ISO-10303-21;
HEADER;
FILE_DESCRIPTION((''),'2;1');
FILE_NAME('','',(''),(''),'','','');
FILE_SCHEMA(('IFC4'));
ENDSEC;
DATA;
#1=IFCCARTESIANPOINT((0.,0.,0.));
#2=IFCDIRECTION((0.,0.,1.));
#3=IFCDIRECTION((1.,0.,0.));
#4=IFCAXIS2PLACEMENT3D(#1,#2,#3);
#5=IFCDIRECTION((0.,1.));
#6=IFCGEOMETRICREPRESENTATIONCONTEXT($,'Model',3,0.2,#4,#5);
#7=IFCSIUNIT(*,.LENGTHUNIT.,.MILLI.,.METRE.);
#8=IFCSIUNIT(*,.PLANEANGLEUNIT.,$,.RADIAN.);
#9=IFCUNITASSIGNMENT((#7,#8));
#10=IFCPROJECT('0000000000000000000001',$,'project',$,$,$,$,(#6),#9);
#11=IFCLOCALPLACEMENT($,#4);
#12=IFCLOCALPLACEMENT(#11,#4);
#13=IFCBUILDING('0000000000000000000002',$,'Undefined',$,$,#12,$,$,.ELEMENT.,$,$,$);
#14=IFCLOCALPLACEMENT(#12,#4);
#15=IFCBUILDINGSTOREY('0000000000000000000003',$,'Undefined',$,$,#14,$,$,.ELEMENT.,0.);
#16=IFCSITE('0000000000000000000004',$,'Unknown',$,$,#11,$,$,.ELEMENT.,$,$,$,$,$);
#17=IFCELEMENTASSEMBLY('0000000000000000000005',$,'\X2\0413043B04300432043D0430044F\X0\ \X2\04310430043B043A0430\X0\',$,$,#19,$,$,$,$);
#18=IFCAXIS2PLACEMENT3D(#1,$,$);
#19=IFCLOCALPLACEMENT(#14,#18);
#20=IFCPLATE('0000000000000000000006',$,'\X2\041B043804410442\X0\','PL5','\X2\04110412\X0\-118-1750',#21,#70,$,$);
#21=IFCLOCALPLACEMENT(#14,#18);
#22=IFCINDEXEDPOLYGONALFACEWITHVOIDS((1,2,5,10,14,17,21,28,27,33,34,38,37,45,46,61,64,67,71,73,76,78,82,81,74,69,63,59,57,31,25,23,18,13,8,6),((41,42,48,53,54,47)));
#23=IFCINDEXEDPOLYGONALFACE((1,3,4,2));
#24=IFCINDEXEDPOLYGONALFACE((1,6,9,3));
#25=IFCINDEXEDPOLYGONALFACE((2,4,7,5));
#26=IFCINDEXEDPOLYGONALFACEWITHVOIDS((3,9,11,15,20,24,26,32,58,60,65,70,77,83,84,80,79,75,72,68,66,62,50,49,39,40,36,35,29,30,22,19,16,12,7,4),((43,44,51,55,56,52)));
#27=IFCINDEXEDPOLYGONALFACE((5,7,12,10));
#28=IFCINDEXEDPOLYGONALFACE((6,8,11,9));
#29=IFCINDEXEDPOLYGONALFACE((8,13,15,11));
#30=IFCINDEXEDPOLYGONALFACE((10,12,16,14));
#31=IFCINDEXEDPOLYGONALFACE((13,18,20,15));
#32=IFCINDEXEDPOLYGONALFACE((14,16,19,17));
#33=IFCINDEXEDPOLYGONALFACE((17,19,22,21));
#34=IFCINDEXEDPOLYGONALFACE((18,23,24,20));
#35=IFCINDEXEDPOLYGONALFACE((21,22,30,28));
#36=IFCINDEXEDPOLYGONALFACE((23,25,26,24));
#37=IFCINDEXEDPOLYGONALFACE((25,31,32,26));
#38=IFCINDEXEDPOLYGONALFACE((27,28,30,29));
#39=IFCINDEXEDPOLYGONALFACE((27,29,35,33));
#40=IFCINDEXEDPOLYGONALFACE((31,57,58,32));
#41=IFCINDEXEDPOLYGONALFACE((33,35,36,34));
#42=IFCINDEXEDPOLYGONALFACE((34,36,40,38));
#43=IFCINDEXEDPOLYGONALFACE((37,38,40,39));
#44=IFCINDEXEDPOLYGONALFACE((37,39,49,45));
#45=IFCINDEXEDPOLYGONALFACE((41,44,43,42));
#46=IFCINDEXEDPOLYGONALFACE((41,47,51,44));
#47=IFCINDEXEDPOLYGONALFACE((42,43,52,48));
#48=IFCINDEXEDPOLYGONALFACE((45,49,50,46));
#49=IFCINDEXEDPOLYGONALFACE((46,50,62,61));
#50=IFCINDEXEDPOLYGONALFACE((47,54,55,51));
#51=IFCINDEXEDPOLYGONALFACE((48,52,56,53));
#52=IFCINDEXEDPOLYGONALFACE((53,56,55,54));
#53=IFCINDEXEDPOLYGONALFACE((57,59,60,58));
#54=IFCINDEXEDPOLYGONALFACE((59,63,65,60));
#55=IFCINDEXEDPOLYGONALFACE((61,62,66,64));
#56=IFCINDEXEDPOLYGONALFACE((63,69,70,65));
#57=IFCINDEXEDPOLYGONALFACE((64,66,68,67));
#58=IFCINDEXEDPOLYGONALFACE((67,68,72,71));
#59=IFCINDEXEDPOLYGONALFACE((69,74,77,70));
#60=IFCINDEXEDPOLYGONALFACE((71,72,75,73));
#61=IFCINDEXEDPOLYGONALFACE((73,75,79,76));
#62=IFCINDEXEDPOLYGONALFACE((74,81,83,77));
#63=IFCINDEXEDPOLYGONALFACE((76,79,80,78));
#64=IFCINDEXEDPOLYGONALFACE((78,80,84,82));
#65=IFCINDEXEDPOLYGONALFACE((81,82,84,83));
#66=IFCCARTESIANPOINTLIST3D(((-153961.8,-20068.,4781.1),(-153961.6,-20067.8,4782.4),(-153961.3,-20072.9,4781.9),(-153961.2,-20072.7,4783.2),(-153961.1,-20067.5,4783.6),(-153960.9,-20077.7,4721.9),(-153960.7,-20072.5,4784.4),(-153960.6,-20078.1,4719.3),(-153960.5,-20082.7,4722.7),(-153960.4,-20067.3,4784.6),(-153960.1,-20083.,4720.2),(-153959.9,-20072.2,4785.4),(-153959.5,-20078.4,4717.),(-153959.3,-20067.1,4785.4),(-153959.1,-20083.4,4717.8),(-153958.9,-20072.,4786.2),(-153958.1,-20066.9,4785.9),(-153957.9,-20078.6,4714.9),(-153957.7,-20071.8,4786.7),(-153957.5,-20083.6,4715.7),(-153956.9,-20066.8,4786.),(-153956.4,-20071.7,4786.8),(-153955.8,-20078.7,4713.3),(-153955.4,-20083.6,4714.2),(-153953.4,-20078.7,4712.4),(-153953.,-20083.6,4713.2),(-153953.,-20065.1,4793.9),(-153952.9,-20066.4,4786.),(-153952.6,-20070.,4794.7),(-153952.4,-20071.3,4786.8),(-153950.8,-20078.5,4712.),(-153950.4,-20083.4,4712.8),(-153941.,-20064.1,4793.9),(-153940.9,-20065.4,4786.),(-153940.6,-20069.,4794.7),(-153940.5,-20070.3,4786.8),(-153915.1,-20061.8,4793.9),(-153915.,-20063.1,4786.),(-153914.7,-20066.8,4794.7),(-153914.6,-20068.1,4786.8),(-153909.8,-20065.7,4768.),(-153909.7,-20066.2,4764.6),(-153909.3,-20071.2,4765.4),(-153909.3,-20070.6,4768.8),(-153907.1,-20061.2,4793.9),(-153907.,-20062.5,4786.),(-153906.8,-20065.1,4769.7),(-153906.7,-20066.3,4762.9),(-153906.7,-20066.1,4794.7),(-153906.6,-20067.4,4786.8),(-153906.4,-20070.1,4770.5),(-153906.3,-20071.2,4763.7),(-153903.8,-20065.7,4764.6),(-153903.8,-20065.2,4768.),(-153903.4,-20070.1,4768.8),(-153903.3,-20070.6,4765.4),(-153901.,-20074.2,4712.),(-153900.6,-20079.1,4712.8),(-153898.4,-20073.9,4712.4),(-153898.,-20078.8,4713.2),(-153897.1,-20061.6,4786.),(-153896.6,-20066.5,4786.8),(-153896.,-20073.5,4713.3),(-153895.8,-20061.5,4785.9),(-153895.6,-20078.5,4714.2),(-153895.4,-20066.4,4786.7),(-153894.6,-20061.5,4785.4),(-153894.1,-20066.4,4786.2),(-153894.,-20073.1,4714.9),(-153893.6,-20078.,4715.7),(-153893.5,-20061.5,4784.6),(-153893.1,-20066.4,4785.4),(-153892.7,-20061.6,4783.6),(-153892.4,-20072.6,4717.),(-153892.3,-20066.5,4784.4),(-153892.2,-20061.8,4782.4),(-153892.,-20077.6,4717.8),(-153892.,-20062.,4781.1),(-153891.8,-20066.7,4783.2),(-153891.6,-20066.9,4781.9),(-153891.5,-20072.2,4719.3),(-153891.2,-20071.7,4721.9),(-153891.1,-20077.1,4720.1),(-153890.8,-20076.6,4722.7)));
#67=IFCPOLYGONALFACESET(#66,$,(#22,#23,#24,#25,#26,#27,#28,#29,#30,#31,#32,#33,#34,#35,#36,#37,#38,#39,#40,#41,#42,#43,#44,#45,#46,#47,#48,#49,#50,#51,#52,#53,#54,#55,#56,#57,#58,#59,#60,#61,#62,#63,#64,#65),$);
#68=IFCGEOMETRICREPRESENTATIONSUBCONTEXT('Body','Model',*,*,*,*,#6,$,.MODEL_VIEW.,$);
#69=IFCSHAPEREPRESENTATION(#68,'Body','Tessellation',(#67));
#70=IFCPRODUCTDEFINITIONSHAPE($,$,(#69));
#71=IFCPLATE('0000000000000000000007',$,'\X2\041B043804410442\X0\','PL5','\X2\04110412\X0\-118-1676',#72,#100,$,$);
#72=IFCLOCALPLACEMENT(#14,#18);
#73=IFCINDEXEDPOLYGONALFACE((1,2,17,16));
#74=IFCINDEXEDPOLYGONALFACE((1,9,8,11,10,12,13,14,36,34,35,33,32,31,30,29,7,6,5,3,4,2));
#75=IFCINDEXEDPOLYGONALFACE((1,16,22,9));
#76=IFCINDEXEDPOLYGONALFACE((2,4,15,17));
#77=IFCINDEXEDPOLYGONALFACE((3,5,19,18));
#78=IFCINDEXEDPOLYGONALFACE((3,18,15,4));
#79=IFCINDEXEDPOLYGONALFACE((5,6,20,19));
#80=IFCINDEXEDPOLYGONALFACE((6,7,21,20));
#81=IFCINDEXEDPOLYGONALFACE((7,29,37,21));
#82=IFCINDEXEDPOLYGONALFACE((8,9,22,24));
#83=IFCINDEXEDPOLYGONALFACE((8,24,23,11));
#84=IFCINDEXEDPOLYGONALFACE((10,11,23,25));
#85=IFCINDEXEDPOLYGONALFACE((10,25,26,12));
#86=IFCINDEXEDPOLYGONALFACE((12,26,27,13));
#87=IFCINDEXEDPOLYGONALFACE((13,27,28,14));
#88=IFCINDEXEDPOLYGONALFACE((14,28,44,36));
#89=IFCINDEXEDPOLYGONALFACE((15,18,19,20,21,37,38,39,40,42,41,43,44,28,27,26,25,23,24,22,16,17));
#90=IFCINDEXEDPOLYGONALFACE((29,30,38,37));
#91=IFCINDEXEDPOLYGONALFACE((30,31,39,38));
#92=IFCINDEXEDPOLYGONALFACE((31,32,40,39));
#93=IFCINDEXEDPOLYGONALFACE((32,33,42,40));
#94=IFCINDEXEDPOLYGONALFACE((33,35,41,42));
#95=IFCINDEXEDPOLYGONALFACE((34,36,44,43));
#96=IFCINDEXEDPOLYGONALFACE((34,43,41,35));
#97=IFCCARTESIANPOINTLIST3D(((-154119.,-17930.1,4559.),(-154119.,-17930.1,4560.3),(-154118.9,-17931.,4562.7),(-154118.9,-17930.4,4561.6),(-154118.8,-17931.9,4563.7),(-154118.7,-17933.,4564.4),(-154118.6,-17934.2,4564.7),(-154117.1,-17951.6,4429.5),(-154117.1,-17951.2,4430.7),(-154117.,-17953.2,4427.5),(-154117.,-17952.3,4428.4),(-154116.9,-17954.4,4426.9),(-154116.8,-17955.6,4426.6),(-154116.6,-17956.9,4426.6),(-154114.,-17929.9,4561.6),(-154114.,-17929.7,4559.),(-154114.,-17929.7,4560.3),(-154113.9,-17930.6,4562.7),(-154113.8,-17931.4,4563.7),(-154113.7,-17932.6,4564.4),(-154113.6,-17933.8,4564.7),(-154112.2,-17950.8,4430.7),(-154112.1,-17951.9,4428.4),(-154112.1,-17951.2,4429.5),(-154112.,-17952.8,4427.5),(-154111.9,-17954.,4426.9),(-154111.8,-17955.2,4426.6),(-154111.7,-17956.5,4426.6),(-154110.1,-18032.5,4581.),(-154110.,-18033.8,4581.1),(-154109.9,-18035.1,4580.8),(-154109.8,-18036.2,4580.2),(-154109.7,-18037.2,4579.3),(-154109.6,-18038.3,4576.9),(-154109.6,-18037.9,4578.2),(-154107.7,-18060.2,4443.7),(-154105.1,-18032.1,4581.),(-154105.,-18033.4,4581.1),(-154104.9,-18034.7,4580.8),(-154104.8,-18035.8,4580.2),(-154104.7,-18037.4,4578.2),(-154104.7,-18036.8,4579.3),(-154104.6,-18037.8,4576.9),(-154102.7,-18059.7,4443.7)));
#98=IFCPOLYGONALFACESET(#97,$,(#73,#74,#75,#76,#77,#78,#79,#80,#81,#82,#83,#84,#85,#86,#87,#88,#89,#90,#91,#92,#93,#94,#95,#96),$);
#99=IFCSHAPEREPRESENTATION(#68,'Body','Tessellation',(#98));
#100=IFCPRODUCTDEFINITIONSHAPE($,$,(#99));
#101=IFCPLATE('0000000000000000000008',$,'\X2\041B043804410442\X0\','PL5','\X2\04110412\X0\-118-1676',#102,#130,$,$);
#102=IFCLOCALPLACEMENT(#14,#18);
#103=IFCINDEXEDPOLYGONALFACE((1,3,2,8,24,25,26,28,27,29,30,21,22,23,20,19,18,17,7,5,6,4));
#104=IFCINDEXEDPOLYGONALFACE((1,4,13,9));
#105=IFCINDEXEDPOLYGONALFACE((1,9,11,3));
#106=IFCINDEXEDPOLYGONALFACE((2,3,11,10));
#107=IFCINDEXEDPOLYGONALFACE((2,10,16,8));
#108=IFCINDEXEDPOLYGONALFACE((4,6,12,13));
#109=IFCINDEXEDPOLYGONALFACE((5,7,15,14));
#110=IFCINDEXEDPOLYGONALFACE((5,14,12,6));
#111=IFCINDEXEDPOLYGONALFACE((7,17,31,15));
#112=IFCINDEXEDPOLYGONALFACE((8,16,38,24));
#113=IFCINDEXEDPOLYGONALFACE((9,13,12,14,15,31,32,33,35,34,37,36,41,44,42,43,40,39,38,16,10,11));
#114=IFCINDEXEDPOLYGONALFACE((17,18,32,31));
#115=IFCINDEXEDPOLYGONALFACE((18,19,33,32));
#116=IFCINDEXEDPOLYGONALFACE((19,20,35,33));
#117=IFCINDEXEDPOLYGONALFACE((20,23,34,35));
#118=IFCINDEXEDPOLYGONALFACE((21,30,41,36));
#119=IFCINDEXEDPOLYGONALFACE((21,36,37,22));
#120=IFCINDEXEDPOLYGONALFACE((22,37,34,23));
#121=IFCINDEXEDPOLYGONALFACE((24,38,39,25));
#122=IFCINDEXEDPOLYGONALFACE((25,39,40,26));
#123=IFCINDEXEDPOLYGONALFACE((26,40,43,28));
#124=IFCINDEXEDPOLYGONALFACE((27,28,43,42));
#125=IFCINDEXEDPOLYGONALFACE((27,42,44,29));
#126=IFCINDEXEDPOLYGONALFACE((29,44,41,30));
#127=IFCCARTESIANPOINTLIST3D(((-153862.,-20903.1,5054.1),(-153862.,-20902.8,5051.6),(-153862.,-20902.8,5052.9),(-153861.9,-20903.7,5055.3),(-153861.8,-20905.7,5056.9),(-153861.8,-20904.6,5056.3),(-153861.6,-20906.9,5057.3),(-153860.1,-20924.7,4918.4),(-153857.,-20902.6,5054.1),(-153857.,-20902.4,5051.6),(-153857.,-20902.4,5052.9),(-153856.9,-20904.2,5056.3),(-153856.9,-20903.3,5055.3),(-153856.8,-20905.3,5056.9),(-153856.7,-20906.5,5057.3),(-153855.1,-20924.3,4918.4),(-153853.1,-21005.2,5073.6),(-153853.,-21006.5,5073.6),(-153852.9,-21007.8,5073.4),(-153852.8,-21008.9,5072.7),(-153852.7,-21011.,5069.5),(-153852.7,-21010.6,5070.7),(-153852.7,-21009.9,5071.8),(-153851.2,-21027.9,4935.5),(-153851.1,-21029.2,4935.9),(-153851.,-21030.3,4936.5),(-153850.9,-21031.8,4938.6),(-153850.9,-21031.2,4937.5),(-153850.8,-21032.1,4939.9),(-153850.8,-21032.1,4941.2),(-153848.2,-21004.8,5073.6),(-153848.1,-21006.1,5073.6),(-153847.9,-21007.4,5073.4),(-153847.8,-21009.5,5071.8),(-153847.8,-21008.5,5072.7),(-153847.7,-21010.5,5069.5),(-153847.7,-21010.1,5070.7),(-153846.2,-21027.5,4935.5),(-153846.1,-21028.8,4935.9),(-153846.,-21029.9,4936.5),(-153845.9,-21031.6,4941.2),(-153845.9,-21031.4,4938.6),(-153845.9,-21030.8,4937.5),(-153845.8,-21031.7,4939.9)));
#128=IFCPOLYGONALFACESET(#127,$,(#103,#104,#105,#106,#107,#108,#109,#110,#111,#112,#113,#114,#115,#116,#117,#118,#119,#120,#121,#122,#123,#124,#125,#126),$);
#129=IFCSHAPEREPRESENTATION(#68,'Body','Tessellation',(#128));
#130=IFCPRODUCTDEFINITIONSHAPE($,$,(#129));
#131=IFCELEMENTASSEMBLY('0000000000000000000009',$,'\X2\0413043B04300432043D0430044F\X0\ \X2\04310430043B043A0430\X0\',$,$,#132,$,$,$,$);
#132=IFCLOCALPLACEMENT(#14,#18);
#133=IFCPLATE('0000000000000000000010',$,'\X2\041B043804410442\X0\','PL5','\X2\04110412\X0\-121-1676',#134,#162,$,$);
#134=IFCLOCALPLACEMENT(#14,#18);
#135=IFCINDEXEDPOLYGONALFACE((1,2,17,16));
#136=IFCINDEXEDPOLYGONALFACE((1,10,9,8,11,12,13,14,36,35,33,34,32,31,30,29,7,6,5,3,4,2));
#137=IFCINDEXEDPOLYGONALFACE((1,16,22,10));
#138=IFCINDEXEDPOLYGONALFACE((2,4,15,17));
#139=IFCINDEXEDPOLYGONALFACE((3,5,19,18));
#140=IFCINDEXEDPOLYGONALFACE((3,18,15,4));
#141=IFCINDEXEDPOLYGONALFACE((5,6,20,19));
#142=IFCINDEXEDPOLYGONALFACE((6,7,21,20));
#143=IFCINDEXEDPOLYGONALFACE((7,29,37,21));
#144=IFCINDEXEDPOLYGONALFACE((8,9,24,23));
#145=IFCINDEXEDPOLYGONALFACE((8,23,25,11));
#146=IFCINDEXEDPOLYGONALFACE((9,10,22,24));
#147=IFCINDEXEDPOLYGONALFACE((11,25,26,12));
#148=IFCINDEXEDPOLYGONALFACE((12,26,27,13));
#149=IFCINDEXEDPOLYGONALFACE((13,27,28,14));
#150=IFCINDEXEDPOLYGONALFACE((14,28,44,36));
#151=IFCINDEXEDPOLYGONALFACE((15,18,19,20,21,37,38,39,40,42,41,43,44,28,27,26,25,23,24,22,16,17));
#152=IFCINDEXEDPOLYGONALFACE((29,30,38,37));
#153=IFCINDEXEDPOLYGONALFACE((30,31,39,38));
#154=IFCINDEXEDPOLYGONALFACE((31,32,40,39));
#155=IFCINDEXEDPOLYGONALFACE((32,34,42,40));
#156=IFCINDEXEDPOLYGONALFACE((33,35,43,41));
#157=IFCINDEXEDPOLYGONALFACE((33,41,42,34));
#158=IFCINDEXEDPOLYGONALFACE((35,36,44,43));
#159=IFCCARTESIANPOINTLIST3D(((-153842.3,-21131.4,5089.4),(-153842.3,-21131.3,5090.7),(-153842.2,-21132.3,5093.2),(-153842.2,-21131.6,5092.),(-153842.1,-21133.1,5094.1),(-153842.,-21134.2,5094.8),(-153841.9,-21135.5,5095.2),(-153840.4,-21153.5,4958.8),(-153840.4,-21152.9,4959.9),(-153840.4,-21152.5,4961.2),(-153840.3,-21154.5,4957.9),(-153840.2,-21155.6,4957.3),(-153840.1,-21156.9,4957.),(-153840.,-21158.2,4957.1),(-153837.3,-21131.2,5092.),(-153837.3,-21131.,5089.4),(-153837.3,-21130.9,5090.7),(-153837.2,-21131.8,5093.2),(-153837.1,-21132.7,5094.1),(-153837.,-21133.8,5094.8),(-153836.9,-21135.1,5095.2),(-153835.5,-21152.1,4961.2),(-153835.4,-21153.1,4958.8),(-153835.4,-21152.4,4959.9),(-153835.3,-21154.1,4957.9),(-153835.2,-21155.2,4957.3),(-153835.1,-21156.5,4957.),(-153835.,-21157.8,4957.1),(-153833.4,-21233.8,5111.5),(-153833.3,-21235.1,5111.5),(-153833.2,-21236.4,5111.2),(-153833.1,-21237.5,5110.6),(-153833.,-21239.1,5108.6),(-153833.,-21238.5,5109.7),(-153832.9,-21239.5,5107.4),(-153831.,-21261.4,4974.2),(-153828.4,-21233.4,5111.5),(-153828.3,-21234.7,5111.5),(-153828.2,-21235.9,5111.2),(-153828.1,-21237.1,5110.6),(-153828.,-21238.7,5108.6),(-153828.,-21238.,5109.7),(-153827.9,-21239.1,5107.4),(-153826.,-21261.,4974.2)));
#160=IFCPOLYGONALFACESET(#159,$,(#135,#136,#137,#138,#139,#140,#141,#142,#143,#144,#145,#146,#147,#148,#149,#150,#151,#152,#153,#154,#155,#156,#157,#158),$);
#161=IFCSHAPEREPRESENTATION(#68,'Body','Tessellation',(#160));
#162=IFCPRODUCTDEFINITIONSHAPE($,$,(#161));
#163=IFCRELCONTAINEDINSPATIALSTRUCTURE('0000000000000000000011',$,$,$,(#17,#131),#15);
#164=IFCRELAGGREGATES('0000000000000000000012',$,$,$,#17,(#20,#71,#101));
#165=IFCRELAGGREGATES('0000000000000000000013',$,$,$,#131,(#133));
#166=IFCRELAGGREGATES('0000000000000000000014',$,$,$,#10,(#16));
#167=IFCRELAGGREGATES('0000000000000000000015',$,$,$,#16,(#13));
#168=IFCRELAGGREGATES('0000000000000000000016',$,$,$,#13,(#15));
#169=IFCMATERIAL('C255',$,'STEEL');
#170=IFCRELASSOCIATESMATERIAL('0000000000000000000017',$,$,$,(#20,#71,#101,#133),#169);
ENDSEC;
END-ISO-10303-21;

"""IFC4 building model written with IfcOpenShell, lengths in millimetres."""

from ifc_helpers import new_model, si_unit, direction, frame, origin_with_axes, place, context, subcontext, project, spatial, line, arc, indexed_curve, outline, extrude, material, element, aggregate, save


model = new_model("IFC4")

# Units and contexts
model_context = context("Model", 3, precision=0.2, world=origin_with_axes(), true_north=direction((0.0, 1.0)))
body_context = subcontext(model_context, "Body", "Model", "MODEL_VIEW")
ifc_project = project(units=[si_unit("LENGTHUNIT", "METRE", prefix="MILLI"), si_unit("PLANEANGLEUNIT", "RADIAN")], contexts=[model_context])

# Site, building, storey
site_placement = place(None, origin_with_axes())
site = spatial("IfcSite", under=ifc_project, at=site_placement, Name="Unknown", CompositionType="ELEMENT")
building_placement = place(site_placement, origin_with_axes())
building = spatial("IfcBuilding", under=site, at=building_placement, Name="Undefined", CompositionType="ELEMENT")
storey_placement = place(building_placement, origin_with_axes())
storey = spatial("IfcBuildingStorey", under=building, at=storey_placement, Name="Undefined", CompositionType="ELEMENT", Elevation=0.0)

# Shared definitions
ifc_material_1 = material(Name="C255", Category="STEEL")

# Element assembly, plates, voiding feature
assembly_1_placement = place(storey_placement, frame((-154120.8, -17880.2, 4484.9), z_axis=(-0.996285, -0.086114, 0.000024), x_axis=(0.084961, -0.982981, 0.162881)))
assembly_1 = element("IfcElementAssembly", 1, at=assembly_1_placement, inside=storey, Name="Главная балка")
plate_1_placement = place(assembly_1_placement, frame((2214.8, -135.0, -40.0), z_axis=(-1.0, -0.000054, 0.0), x_axis=(0.0, 0.000054, 1.0)))
plate_1 = element("IfcPlate", 2, at=plate_1_placement, material=ifc_material_1, Name="Лист", Description="PL5", ObjectType="БВ-118-1750", context=body_context, shape_type="SolidModel", body=[
    extrude(outline(indexed_curve([(0.0, 10.0), (2.9, 2.9), (10.0, 0.0), (60.0, 0.0), (67.1, 2.9), (70.0, 10.0), (70.0, 70.0), (68.5, 73.5), (65.0, 75.0), (61.0, 75.0), (61.0, 83.0), (49.0, 83.0), (49.0, 75.0), (23.0, 75.0), (23.0, 83.0), (15.0, 83.0), (15.0, 75.0), (5.0, 75.0), (1.5, 73.5), (0.0, 70.0)], segments=[arc(1, 2, 3), line(3, 4), arc(4, 5, 6), line(6, 7), arc(7, 8, 9), line(9, 10, 11, 12, 13, 14, 15, 16, 17, 18), arc(18, 19, 20), line(20, 1)])), frame((0.0, 0.0, 2.5), z_axis=(0.0, 0.0, 1.0), x_axis=(1.0, 0.0, 0.0)), (0.0, 0.0, -1.0), 5.0),
])
voiding_feature_1_placement = place(plate_1_placement, frame((15.0, 55.0, 10.0), z_axis=(0.007997, -0.999968, -0.000026), x_axis=(0.0, 0.000026, -1.0)))
element("IfcVoidingFeature", 3, at=voiding_feature_1_placement, cuts=plate_1, Name="Балка", ObjectType="(?)", PredefinedType="HOLE", context=body_context, shape_type="SolidModel", body=[
    extrude(outline(indexed_curve([(1.7, -3.0), (3.5, 0.0), (1.7, 3.0), (-1.7, 3.0), (-3.5, 0.0), (-1.7, -3.0)], segments=[line(1, 2, 3, 4, 5, 6, 1)])), frame((0.0, 0.0, 0.0), z_axis=(-1.0, 0.0, 0.0), x_axis=(0.0, 0.0, 1.0)), (0.0, 0.0, -1.0), 20.0),
])
plate_2_placement = place(assembly_1_placement, frame((61.3, 70.0, 0.0), z_axis=(0.0, 0.0, 1.0), x_axis=(0.0, -1.0, 0.0)))
plate_2 = element("IfcPlate", 4, at=plate_2_placement, material=ifc_material_1, Name="Лист", Description="PL5", ObjectType="БВ-118-1676", context=body_context, shape_type="SolidModel", body=[
    extrude(outline(indexed_curve([(0.0, 5.0), (1.5, 1.5), (5.0, 0.0), (135.0, 0.0), (138.5, 1.5), (140.0, 5.0), (140.0, 110.0), (5.0, 110.0), (1.5, 108.5), (0.0, 105.0)], segments=[arc(1, 2, 3), line(3, 4), arc(4, 5, 6), line(6, 7, 8), arc(8, 9, 10), line(10, 1)])), frame((0.0, 0.0, 2.5), z_axis=(0.0, 0.0, 1.0), x_axis=(1.0, 0.0, 0.0)), (0.0, 0.0, -1.0), 5.0),
])
plate_3_placement = place(assembly_1_placement, frame((3195.4, 70.0, 0.0), z_axis=(0.0, 0.0, -1.0), x_axis=(0.0, -1.0, 0.0)))
plate_3 = element("IfcPlate", 5, at=plate_3_placement, material=ifc_material_1, Name="Лист", Description="PL5", ObjectType="БВ-118-1676", context=body_context, shape_type="SolidModel", body=[
    extrude(outline(indexed_curve([(0.0, 5.0), (1.5, 1.5), (5.0, 0.0), (135.0, 0.0), (138.5, 1.5), (140.0, 5.0), (140.0, 110.0), (5.0, 110.0), (1.5, 108.5), (0.0, 105.0)], segments=[arc(1, 2, 3), line(3, 4), arc(4, 5, 6), line(6, 7, 8), arc(8, 9, 10), line(10, 1)])), frame((0.0, 0.0, 2.5), z_axis=(0.0, 0.0, 1.0), x_axis=(1.0, 0.0, 0.0)), (0.0, 0.0, -1.0), 5.0),
])
aggregate(assembly_1, [plate_1, plate_2, plate_3])

# Element assembly, plate
assembly_2_placement = place(storey_placement, frame((-153842.1, -21103.9, 5019.0), z_axis=(-0.996285, -0.086114, 0.000024), x_axis=(0.084961, -0.982981, 0.162881)))
assembly_2 = element("IfcElementAssembly", 6, at=assembly_2_placement, inside=storey, Name="Главная балка")
plate_4_placement = place(assembly_2_placement, frame((38.5, 70.0, 0.0), z_axis=(0.0, 0.0, 1.0), x_axis=(0.0, -1.0, 0.0)))
plate_4 = element("IfcPlate", 7, at=plate_4_placement, material=ifc_material_1, Name="Лист", Description="PL5", ObjectType="БВ-121-1676", context=body_context, shape_type="SolidModel", body=[
    extrude(outline(indexed_curve([(0.0, 5.0), (1.5, 1.5), (5.0, 0.0), (135.0, 0.0), (138.5, 1.5), (140.0, 5.0), (140.0, 110.0), (5.0, 110.0), (1.5, 108.5), (0.0, 105.0)], segments=[arc(1, 2, 3), line(3, 4), arc(4, 5, 6), line(6, 7, 8), arc(8, 9, 10), line(10, 1)])), frame((0.0, 0.0, 2.5), z_axis=(0.0, 0.0, 1.0), x_axis=(1.0, 0.0, 0.0)), (0.0, 0.0, -1.0), 5.0),
])
aggregate(assembly_2, [plate_4])

save(model, "model.ifc")
